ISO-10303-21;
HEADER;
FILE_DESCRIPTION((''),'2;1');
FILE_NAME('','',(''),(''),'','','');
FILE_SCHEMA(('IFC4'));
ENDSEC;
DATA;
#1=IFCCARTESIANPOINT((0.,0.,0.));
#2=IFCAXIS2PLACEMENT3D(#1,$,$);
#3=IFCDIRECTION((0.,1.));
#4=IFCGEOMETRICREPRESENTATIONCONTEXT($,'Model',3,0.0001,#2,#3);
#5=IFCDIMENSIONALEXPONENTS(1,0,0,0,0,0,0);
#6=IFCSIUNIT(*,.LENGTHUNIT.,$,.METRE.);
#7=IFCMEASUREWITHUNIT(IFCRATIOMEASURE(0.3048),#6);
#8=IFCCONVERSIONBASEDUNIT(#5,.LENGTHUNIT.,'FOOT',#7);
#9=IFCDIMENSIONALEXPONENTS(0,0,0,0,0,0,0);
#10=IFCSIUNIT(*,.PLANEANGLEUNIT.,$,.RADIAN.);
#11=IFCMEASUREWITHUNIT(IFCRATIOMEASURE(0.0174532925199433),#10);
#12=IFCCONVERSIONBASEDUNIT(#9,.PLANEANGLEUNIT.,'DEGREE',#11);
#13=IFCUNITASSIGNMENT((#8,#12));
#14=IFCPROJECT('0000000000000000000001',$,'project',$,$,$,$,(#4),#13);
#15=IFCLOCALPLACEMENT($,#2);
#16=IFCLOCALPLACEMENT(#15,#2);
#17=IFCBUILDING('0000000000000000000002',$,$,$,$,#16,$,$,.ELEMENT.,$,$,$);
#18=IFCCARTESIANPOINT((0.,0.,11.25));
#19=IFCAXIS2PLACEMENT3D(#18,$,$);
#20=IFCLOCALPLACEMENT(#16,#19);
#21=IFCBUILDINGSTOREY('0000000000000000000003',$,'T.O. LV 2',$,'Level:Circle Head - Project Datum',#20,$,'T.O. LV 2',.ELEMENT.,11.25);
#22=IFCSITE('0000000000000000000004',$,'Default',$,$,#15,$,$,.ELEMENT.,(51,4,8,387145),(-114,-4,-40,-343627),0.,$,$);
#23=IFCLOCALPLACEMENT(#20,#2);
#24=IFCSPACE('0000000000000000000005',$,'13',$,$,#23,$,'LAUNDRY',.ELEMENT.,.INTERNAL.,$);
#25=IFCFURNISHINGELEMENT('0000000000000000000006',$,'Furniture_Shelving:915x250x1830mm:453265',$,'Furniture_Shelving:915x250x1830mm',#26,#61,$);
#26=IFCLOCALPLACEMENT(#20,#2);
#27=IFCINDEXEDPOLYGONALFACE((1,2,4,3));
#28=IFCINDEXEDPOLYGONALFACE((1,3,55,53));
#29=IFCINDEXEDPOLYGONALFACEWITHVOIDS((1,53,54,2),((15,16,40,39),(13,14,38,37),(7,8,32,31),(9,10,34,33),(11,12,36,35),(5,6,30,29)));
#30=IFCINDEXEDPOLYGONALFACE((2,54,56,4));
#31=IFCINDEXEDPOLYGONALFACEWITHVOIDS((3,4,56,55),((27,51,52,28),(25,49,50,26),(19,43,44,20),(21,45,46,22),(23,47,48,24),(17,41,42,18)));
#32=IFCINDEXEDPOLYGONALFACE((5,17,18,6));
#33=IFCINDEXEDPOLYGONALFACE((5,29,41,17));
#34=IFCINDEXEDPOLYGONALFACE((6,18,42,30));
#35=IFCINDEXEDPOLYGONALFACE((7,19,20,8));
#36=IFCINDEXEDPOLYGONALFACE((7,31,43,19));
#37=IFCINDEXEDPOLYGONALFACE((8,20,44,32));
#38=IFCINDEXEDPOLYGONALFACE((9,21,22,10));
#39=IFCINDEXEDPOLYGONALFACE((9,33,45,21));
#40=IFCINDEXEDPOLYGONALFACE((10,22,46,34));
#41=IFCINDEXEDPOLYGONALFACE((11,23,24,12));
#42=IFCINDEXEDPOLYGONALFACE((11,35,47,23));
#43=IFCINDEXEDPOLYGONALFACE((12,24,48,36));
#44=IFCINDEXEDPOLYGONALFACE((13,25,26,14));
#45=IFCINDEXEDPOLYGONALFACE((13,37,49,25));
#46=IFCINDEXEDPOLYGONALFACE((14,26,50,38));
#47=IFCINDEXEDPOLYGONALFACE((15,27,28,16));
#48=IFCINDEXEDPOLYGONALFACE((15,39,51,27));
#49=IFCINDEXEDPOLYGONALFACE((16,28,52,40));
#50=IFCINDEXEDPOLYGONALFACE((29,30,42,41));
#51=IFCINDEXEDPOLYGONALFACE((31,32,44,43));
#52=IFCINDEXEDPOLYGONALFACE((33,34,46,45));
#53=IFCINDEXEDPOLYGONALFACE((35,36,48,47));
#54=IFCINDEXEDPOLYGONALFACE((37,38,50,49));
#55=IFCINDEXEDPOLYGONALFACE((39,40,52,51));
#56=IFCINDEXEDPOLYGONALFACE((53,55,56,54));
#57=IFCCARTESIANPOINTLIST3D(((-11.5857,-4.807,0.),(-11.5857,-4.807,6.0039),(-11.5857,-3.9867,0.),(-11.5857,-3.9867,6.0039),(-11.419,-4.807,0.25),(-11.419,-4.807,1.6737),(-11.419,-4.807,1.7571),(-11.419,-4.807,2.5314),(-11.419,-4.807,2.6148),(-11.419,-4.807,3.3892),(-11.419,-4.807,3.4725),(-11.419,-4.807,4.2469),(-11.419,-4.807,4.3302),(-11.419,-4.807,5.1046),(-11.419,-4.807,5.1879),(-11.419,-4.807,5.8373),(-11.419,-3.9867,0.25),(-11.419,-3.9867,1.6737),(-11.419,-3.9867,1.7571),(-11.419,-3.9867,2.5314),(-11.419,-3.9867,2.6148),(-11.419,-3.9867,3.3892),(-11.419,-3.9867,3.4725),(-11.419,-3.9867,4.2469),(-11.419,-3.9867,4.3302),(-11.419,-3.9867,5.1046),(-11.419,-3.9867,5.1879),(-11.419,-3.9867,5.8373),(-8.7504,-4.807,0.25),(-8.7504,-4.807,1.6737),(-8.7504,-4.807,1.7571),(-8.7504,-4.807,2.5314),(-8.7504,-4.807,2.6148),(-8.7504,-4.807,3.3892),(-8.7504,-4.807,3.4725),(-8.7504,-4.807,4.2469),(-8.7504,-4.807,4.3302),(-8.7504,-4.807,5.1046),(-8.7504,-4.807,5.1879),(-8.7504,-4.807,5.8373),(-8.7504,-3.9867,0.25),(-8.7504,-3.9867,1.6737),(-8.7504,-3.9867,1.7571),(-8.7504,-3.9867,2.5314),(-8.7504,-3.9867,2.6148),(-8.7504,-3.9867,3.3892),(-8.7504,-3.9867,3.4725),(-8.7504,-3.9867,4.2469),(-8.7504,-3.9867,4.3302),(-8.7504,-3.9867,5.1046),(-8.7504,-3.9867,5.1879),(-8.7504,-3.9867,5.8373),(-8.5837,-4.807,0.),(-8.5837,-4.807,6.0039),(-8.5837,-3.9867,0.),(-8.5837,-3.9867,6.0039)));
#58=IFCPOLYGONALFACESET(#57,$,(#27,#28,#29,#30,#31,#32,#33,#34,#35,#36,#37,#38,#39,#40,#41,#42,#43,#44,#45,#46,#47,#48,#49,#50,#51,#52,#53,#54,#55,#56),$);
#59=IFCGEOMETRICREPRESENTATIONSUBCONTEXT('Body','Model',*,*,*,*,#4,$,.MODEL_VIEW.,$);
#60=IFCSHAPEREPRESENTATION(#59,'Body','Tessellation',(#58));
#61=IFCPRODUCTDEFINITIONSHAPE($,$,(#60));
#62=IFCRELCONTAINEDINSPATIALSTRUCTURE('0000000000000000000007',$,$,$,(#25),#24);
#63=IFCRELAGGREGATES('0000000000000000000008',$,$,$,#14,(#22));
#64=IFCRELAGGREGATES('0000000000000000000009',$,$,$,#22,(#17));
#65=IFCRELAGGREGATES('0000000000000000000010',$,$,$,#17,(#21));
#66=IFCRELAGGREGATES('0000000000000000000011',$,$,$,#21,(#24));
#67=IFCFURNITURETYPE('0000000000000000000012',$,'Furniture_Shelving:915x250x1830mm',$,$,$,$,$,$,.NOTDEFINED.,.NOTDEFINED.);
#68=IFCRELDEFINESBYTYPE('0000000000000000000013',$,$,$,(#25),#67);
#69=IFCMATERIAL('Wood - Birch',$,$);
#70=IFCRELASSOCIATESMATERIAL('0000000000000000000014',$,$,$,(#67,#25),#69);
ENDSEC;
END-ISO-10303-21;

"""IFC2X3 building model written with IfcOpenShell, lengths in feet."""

from ifc_helpers import new_model, entity, si_unit, converted_unit, direction, frame, origin, place, context, subcontext, project, spatial, polyline, outline, extrude, source, transform, mapped, material, type_object, type_shapes, element, save


model = new_model("IFC2X3")

# Units and contexts
model_context = context("Model", 3, precision=0.0001, world=origin(), true_north=direction((0.0, 1.0)))
body_context = subcontext(model_context, "Body", "Model", "MODEL_VIEW")
ifc_project = project(units=[converted_unit("LENGTHUNIT", "FOOT", entity("IfcRatioMeasure", 0.3048), si_unit("LENGTHUNIT", "METRE"), dimensions=[1, 0, 0, 0, 0, 0, 0]), converted_unit("PLANEANGLEUNIT", "DEGREE", entity("IfcRatioMeasure", 0.0174532925199433), si_unit("PLANEANGLEUNIT", "RADIAN"), dimensions=[0, 0, 0, 0, 0, 0, 0])], contexts=[model_context])

# Site, building, storey
site_placement = place(None, origin())
site = spatial("IfcSite", under=ifc_project, at=site_placement, Name="Default", CompositionType="ELEMENT", RefLatitude=(51, 4, 8, 387145), RefLongitude=(-114, -4, -40, -343627), RefElevation=0.0)
building_placement = place(site_placement, origin())
building = spatial("IfcBuilding", under=site, at=building_placement, CompositionType="ELEMENT")
storey_placement = place(building_placement, frame((0.0, 0.0, 11.25)))
storey = spatial("IfcBuildingStorey", under=building, at=storey_placement, Name="T.O. LV 2", ObjectType="Level:Circle Head - Project Datum", LongName="T.O. LV 2", CompositionType="ELEMENT", Elevation=11.25)

# Shared definitions
space_placement = place(storey_placement, origin())
space = spatial("IfcSpace", under=storey, at=space_placement, Name="13", LongName="LAUNDRY", CompositionType="ELEMENT", InteriorOrExteriorSpace="INTERNAL")

# Furnishing element
ifc_material_1 = material(Name="Wood - Birch")
furniture_type = type_object("IfcFurnitureType", Name="Furniture_Shelving:915x250x1830mm", material=ifc_material_1)
shared_shape_1 = source(origin(), body_context, "Body", "SweptSolid", [
    extrude(outline(polyline([(-1.501, -3.002), (1.501, -3.002), (1.501, 3.002), (-1.501, 3.002), (-1.501, -3.002)]), holes=[polyline([(-1.3343, 2.8353), (1.3343, 2.8353), (1.3343, 2.1859), (-1.3343, 2.1859), (-1.3343, 2.8353)]), polyline([(-1.3343, -2.752), (-1.3343, -1.3282), (1.3343, -1.3282), (1.3343, -2.752), (-1.3343, -2.752)]), polyline([(1.3343, 0.4705), (-1.3343, 0.4705), (-1.3343, 1.2449), (1.3343, 1.2449), (1.3343, 0.4705)]), polyline([(-1.3343, 2.1026), (1.3343, 2.1026), (1.3343, 1.3282), (-1.3343, 1.3282), (-1.3343, 2.1026)]), polyline([(-1.3343, 0.3872), (1.3343, 0.3872), (1.3343, -0.3872), (-1.3343, -0.3872), (-1.3343, 0.3872)]), polyline([(-1.3343, -0.4705), (1.3343, -0.4705), (1.3343, -1.2449), (-1.3343, -1.2449), (-1.3343, -0.4705)])]), frame((0.0, -1.4101, 3.002), z_axis=(0.0, 1.0, 0.0), x_axis=(-1.0, 0.0, 0.0)), (0.0, 0.0, 1.0), 0.8202),
])
type_shapes(furniture_type, [shared_shape_1])
furnishing_placement = place(space_placement, frame((-10.0847, -3.3969, 0.0)))
element("IfcFurnishingElement", 1, at=furnishing_placement, inside=space, type_object=furniture_type, material=ifc_material_1, Name="Furniture_Shelving:915x250x1830mm:453265", ObjectType="Furniture_Shelving:915x250x1830mm", context=body_context, shape_type="MappedRepresentation", body=[
    mapped(shared_shape_1, transform((0.0, 0.0, 0.0), scale=1.0)),
])

save(model, "model.ifc")
